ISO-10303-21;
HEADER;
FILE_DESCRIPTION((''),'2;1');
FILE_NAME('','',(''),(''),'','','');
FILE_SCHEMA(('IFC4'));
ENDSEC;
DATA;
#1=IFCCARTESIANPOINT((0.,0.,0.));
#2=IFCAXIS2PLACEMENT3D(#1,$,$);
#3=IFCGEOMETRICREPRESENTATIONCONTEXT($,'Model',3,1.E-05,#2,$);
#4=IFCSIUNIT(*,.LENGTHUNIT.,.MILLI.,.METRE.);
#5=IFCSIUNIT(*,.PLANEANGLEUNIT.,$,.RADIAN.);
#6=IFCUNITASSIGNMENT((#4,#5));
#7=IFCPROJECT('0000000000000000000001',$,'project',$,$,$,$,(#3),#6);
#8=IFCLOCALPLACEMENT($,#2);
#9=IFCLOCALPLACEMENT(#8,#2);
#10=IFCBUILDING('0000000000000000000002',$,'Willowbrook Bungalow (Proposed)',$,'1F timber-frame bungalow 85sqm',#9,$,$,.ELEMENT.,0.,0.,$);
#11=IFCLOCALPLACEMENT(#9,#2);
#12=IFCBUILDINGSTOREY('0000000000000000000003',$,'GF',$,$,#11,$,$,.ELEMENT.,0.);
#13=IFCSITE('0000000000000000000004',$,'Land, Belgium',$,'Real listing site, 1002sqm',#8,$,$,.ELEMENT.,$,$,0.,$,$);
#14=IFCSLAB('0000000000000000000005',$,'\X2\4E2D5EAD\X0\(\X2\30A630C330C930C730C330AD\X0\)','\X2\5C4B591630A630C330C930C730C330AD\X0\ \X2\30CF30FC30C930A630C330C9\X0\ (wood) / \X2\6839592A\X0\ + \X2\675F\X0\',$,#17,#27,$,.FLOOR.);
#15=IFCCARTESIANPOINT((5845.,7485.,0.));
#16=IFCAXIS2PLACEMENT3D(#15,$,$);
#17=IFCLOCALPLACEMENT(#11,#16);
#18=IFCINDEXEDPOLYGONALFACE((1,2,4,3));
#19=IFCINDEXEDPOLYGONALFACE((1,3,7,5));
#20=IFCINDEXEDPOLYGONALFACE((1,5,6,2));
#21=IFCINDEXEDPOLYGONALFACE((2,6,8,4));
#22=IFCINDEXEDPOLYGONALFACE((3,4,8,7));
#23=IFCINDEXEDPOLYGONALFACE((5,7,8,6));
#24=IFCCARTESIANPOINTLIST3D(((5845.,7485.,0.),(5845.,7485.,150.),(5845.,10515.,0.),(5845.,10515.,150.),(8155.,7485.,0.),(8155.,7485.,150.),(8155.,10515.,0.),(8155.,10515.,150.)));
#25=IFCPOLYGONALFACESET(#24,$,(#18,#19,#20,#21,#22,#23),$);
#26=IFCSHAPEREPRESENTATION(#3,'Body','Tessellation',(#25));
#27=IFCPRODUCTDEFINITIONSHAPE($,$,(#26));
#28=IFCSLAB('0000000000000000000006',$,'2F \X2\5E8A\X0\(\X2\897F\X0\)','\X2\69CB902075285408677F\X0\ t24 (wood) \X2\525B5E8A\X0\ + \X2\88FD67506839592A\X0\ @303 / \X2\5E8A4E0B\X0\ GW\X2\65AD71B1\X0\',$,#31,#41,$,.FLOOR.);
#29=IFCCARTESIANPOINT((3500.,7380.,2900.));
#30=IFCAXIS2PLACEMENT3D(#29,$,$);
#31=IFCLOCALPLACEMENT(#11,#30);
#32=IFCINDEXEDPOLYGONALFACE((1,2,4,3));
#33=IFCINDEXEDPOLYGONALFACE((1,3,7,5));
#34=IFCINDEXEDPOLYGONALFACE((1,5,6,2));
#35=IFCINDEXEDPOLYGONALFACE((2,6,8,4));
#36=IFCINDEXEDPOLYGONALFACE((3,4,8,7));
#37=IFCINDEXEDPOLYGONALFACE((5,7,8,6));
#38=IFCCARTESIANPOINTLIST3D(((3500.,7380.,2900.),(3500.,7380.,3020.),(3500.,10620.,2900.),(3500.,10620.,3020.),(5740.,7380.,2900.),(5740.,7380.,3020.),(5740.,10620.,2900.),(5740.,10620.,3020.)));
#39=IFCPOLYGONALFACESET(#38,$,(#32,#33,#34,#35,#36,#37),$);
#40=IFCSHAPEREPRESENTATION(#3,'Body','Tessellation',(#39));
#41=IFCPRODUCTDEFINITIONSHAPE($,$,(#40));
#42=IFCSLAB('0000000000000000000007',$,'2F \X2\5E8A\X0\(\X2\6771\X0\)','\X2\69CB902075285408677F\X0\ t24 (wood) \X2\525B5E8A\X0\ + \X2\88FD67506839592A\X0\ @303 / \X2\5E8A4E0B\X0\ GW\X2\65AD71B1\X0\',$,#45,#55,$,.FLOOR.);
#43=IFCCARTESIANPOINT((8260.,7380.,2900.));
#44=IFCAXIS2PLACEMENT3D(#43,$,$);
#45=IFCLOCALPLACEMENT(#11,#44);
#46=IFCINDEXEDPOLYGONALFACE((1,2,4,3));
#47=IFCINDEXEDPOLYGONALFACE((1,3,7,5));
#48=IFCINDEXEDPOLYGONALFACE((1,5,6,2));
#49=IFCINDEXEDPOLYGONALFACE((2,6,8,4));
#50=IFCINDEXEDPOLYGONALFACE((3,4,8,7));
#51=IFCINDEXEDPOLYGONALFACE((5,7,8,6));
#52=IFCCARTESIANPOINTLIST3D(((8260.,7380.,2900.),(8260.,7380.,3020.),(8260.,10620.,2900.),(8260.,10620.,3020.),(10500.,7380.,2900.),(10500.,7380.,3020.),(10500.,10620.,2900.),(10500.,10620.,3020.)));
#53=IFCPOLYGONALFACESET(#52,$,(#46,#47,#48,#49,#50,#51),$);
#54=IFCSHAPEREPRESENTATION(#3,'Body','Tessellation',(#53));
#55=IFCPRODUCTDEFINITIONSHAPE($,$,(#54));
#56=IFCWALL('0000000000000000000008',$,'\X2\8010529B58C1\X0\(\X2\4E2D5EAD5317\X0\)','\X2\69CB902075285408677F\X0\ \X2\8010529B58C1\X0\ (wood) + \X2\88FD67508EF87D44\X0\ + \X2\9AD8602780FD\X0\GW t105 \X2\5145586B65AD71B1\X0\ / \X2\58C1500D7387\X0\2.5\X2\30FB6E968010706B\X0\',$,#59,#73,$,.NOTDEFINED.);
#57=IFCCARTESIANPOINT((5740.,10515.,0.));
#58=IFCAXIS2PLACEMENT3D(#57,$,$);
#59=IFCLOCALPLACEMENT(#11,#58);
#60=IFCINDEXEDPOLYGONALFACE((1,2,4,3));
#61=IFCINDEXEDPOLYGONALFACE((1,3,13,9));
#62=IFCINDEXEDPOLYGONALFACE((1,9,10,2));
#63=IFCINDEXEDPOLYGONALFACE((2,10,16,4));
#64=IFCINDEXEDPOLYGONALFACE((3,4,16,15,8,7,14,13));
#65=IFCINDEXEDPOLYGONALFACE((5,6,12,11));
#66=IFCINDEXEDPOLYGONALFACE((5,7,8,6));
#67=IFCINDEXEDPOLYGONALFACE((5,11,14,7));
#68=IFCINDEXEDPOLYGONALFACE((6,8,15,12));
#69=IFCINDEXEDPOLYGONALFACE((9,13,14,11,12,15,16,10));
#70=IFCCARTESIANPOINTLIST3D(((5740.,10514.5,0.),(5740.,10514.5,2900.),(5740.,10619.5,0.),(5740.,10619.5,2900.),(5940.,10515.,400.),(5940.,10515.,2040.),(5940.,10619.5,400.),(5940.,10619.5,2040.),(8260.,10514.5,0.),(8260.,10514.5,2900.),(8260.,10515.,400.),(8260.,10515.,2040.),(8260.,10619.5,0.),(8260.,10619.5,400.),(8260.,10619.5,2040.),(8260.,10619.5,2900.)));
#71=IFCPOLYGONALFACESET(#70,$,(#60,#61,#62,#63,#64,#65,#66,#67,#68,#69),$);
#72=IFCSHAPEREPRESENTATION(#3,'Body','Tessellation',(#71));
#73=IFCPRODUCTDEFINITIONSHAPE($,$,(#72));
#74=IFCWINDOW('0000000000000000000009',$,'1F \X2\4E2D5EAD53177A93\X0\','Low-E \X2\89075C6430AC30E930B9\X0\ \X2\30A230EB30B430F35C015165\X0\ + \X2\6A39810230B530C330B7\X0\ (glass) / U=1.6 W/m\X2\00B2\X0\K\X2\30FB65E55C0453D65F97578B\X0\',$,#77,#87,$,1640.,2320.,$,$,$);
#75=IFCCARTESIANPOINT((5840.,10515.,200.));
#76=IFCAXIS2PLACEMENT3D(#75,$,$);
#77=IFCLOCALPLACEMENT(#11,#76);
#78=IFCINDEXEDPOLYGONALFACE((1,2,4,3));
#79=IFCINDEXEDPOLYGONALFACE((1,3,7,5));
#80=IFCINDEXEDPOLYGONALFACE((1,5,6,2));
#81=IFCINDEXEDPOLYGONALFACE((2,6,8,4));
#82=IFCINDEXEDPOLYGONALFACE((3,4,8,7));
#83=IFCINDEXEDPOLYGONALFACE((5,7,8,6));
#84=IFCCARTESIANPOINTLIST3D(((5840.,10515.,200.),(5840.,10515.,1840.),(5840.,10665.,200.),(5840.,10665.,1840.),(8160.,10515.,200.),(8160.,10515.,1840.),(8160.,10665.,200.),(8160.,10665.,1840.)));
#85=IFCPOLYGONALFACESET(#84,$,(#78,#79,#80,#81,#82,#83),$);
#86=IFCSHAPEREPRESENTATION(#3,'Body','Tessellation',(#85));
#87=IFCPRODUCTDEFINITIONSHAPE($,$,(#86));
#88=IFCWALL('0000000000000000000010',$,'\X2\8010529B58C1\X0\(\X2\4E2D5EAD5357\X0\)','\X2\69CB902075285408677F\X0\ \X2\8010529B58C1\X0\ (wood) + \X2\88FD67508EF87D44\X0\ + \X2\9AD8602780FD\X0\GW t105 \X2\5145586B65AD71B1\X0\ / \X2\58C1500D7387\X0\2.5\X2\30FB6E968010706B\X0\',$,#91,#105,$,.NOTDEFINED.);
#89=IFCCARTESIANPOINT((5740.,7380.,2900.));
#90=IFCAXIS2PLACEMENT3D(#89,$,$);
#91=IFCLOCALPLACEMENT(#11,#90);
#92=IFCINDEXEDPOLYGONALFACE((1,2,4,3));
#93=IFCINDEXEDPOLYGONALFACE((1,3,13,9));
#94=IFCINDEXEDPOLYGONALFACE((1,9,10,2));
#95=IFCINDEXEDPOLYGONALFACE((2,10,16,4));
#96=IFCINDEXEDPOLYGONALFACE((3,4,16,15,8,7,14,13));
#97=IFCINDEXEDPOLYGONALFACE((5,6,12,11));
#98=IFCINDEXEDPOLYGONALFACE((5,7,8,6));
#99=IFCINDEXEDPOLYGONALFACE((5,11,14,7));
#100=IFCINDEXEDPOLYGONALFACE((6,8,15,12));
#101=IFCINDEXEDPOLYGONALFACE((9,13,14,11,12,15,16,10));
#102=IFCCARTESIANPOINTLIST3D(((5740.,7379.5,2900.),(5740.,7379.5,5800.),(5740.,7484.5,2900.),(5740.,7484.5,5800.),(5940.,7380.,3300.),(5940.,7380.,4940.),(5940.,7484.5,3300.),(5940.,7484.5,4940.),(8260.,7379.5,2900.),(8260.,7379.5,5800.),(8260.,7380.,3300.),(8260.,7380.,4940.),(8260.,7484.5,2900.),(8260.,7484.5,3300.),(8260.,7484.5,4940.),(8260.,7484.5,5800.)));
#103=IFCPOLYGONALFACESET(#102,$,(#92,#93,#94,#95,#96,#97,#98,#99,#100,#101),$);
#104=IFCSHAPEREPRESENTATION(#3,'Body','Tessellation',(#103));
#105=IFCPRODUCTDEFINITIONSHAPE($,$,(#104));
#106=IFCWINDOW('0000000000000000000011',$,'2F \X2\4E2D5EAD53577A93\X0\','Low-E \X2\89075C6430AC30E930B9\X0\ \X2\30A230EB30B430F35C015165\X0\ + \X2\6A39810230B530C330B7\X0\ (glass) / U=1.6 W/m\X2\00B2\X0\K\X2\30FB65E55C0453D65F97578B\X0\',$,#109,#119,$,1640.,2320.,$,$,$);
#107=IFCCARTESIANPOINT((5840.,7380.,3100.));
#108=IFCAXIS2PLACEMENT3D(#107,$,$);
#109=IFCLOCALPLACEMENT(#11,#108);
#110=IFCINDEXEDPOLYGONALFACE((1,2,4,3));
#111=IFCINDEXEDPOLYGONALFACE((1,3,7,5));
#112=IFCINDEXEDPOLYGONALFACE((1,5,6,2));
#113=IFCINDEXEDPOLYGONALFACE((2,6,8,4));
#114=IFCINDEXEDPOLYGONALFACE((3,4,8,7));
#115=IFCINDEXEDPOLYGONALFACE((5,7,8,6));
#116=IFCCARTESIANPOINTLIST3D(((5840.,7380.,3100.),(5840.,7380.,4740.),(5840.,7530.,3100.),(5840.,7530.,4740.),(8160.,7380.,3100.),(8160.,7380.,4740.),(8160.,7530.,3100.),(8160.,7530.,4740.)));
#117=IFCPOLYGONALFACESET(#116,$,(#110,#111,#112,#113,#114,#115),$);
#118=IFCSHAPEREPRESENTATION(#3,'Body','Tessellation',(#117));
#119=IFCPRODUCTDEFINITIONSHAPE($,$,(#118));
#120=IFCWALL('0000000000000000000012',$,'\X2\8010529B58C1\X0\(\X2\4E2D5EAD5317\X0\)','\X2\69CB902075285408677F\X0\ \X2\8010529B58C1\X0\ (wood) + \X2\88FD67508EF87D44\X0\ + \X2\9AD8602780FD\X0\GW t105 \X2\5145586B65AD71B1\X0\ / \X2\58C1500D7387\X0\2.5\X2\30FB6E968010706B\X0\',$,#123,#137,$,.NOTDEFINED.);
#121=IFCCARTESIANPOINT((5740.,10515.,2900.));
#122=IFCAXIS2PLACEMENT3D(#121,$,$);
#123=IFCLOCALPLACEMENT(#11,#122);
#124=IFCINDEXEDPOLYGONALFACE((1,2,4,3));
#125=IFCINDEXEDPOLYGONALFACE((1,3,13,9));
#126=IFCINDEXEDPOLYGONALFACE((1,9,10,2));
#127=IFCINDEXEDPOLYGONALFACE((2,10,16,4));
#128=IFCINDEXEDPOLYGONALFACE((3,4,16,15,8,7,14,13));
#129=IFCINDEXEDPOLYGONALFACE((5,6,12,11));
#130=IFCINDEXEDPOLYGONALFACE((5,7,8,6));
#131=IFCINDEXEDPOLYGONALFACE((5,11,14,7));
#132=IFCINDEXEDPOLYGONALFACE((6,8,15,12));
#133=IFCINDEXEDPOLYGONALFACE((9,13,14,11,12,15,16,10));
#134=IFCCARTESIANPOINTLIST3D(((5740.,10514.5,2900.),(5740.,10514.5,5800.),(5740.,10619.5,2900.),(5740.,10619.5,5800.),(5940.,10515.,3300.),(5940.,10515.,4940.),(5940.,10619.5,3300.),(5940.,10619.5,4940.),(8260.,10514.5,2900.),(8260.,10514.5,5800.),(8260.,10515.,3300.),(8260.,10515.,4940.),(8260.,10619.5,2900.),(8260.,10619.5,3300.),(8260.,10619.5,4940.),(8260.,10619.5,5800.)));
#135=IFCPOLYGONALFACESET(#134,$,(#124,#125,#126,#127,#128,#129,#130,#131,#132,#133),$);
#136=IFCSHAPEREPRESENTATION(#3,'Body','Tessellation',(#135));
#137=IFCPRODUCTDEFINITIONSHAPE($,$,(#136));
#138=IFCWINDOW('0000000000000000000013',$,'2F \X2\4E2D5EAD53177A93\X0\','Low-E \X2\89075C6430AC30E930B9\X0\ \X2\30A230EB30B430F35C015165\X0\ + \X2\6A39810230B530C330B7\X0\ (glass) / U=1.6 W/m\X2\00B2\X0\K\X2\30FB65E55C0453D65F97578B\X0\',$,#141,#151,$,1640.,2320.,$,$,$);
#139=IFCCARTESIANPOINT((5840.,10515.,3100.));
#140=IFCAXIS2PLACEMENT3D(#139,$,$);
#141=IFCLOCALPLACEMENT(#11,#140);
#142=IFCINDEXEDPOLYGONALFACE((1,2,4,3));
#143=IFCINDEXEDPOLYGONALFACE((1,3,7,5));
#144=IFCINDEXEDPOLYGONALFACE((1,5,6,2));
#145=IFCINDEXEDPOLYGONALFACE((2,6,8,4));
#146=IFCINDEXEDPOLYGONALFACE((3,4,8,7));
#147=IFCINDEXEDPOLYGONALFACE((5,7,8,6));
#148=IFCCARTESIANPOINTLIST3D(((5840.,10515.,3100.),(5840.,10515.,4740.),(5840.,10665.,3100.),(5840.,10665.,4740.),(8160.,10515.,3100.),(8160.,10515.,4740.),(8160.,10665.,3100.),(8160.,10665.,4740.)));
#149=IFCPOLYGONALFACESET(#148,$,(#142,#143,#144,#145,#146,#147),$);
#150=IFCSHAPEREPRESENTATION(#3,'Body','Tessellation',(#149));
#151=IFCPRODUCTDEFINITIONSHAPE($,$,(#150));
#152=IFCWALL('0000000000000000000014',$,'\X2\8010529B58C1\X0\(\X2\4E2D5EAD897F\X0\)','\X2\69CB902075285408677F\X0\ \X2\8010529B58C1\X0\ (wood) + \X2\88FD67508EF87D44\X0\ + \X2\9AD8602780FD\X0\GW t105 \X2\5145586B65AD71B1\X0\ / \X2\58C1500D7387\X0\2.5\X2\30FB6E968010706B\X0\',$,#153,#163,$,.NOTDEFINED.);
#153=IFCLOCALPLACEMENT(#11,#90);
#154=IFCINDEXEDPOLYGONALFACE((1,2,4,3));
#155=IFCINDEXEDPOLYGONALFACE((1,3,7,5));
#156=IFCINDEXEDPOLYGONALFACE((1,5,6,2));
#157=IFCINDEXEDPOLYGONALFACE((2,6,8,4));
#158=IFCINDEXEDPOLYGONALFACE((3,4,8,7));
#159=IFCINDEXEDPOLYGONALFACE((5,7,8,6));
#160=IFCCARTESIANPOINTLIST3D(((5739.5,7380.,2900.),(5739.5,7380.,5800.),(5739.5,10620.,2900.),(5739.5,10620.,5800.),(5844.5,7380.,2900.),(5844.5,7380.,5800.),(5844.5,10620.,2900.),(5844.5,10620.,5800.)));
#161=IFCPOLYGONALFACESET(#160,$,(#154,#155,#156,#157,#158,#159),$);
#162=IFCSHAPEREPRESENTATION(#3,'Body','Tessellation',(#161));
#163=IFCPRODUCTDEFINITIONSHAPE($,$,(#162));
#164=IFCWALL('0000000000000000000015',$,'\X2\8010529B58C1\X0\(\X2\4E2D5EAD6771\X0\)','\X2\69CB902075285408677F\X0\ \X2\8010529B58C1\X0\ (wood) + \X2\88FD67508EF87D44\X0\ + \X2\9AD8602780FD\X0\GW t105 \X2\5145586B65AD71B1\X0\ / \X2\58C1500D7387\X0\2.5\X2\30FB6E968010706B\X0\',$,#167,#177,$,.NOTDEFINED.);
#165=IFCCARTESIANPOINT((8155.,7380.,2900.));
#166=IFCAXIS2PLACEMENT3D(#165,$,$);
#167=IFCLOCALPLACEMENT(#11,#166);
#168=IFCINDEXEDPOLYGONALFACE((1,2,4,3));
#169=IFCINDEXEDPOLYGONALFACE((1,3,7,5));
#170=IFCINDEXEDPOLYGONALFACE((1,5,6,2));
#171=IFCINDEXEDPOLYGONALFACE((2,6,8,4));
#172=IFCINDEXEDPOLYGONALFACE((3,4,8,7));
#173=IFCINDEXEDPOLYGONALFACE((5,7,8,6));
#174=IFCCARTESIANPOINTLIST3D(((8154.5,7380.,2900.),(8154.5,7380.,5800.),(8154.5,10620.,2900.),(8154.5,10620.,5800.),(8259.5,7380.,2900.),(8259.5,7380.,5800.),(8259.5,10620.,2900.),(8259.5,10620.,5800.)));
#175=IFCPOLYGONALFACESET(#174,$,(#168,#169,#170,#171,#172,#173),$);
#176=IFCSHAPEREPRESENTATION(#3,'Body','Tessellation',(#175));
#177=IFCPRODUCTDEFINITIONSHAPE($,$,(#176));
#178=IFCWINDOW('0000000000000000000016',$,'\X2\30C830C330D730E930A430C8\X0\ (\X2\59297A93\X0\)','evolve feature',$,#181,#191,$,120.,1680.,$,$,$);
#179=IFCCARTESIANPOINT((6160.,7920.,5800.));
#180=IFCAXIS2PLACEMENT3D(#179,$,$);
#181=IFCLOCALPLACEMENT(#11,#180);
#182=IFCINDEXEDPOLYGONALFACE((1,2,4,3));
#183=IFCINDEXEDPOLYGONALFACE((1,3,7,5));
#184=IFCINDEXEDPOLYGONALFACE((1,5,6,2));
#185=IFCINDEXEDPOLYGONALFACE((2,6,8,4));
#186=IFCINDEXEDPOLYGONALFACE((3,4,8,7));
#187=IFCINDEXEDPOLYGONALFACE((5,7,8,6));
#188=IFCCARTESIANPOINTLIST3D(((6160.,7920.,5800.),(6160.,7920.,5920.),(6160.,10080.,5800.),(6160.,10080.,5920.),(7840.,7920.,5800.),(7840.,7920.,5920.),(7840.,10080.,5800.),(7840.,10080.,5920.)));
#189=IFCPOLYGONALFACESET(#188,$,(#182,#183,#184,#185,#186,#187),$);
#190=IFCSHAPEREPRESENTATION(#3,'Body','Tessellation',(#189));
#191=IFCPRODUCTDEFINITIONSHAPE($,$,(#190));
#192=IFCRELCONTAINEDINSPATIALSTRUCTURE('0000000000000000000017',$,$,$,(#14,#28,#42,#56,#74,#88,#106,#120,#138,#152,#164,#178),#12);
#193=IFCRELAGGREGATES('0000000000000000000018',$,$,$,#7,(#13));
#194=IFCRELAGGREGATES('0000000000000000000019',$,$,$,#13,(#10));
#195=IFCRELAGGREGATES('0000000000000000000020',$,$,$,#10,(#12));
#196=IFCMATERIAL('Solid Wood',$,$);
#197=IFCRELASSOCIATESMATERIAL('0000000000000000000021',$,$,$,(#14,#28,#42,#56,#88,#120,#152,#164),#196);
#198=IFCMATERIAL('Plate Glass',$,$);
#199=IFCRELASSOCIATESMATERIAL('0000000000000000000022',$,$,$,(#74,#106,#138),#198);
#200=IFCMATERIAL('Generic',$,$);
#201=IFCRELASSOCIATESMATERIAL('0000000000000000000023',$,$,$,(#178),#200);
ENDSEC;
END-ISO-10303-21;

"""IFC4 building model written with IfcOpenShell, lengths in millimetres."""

from ifc_helpers import new_model, si_unit, frame, frame_2d, origin, place, context, project, spatial, rectangle, extrude, material, element, fill, save


model = new_model("IFC4")

# Units and contexts
model_context = context("Model", 3, precision=1e-05, world=origin())
ifc_project = project(units=[si_unit("LENGTHUNIT", "METRE", prefix="MILLI"), si_unit("PLANEANGLEUNIT", "RADIAN")], contexts=[model_context])

# Site, building, storey
site_placement = place(None, origin())
site = spatial("IfcSite", under=ifc_project, at=site_placement, Name="Land, Belgium", ObjectType="Real listing site, 1002sqm", CompositionType="ELEMENT", RefElevation=0.0)
building_placement = place(site_placement, origin())
building = spatial("IfcBuilding", under=site, at=building_placement, Name="Willowbrook Bungalow (Proposed)", ObjectType="1F timber-frame bungalow 85sqm", CompositionType="ELEMENT", ElevationOfRefHeight=0.0, ElevationOfTerrain=0.0)
storey_placement = place(building_placement, origin())
storey = spatial("IfcBuildingStorey", under=building, at=storey_placement, Name="GF", CompositionType="ELEMENT", Elevation=0.0)

# Slabs
ifc_material_1 = material(Name="Solid Wood")
slab_1_placement = place(storey_placement, frame((5845.0, 7485.0, 0.0)))
element("IfcSlab", 1, at=slab_1_placement, inside=storey, material=ifc_material_1, Name="中庭(ウッドデッキ)", Description="屋外ウッドデッキ ハードウッド (wood) / 根太 + 束", PredefinedType="FLOOR", context=model_context, shape_type="SweptSolid", body=[
    extrude(rectangle(XDim=2310.0, YDim=3030.0, at=frame_2d((1155.0, 1515.0))), frame((5845.0, 7485.0, 0.0)), (0.0, 0.0, 1.0), 150.0),
])
slab_2_placement = place(storey_placement, frame((3500.0, 7380.0, 2900.0)))
element("IfcSlab", 2, at=slab_2_placement, inside=storey, material=ifc_material_1, Name="2F 床(西)", Description="構造用合板 t24 (wood) 剛床 + 製材根太 @303 / 床下 GW断熱", PredefinedType="FLOOR", context=model_context, shape_type="SweptSolid", body=[
    extrude(rectangle(XDim=2240.0, YDim=3240.0, at=frame_2d((1120.0, 1620.0))), frame((3500.0, 7380.0, 2900.0)), (0.0, 0.0, 1.0), 120.0),
])
slab_3_placement = place(storey_placement, frame((8260.0, 7380.0, 2900.0)))
element("IfcSlab", 3, at=slab_3_placement, inside=storey, material=ifc_material_1, Name="2F 床(東)", Description="構造用合板 t24 (wood) 剛床 + 製材根太 @303 / 床下 GW断熱", PredefinedType="FLOOR", context=model_context, shape_type="SweptSolid", body=[
    extrude(rectangle(XDim=2240.0, YDim=3240.0, at=frame_2d((1120.0, 1620.0))), frame((8260.0, 7380.0, 2900.0)), (0.0, 0.0, 1.0), 120.0),
])

# Walls, openings, windows
wall_1_placement = place(storey_placement, frame((5740.0, 10515.0, 0.0)))
wall_1 = element("IfcWall", 4, at=wall_1_placement, inside=storey, material=ifc_material_1, Name="耐力壁(中庭北)", Description="構造用合板 耐力壁 (wood) + 製材軸組 + 高性能GW t105 充填断熱 / 壁倍率2.5・準耐火", PredefinedType="NOTDEFINED", context=model_context, shape_type="SweptSolid", body=[
    extrude(rectangle(XDim=2520.0, YDim=105.0, at=frame_2d((1260.0, 52.0))), frame((5740.0, 10515.0, 0.0)), (0.0, 0.0, 1.0), 2900.0),
])
opening_1_placement = place(storey_placement, frame((5840.0, 10515.0, 200.0)))
opening_1 = element("IfcOpeningElement", 5, at=opening_1_placement, cuts=wall_1, PredefinedType="NOTDEFINED", context=model_context, shape_type="SweptSolid", body=[
    extrude(rectangle(XDim=2320.0, YDim=150.0, at=frame_2d((1160.0, 75.0))), frame((5840.0, 10515.0, 200.0)), (0.0, 0.0, 1.0), 1640.0),
])
ifc_material_2 = material(Name="Plate Glass")
window_1_placement = place(storey_placement, frame((5840.0, 10515.0, 200.0)))
window_1 = element("IfcWindow", 6, at=window_1_placement, inside=storey, material=ifc_material_2, Name="1F 中庭北窓", Description="Low-E 複層ガラス アルゴン封入 + 樹脂サッシ (glass) / U=1.6 W/m²K・日射取得型", OverallHeight=1640.0, OverallWidth=2320.0, context=model_context, shape_type="SweptSolid", body=[
    extrude(rectangle(XDim=2320.0, YDim=150.0, at=frame_2d((1160.0, 75.0))), frame((5840.0, 10515.0, 200.0)), (0.0, 0.0, 1.0), 1640.0),
])
fill(opening_1, window_1)
wall_2_placement = place(storey_placement, frame((5740.0, 7380.0, 2900.0)))
wall_2 = element("IfcWall", 7, at=wall_2_placement, inside=storey, material=ifc_material_1, Name="耐力壁(中庭南)", Description="構造用合板 耐力壁 (wood) + 製材軸組 + 高性能GW t105 充填断熱 / 壁倍率2.5・準耐火", PredefinedType="NOTDEFINED", context=model_context, shape_type="SweptSolid", body=[
    extrude(rectangle(XDim=2520.0, YDim=105.0, at=frame_2d((1260.0, 52.0))), frame((5740.0, 7380.0, 2900.0)), (0.0, 0.0, 1.0), 2900.0),
])
opening_2_placement = place(storey_placement, frame((5840.0, 7380.0, 3100.0)))
opening_2 = element("IfcOpeningElement", 8, at=opening_2_placement, cuts=wall_2, PredefinedType="NOTDEFINED", context=model_context, shape_type="SweptSolid", body=[
    extrude(rectangle(XDim=2320.0, YDim=150.0, at=frame_2d((1160.0, 75.0))), frame((5840.0, 7380.0, 3100.0)), (0.0, 0.0, 1.0), 1640.0),
])
window_2_placement = place(storey_placement, frame((5840.0, 7380.0, 3100.0)))
window_2 = element("IfcWindow", 9, at=window_2_placement, inside=storey, material=ifc_material_2, Name="2F 中庭南窓", Description="Low-E 複層ガラス アルゴン封入 + 樹脂サッシ (glass) / U=1.6 W/m²K・日射取得型", OverallHeight=1640.0, OverallWidth=2320.0, context=model_context, shape_type="SweptSolid", body=[
    extrude(rectangle(XDim=2320.0, YDim=150.0, at=frame_2d((1160.0, 75.0))), frame((5840.0, 7380.0, 3100.0)), (0.0, 0.0, 1.0), 1640.0),
])
fill(opening_2, window_2)
wall_3_placement = place(storey_placement, frame((5740.0, 10515.0, 2900.0)))
wall_3 = element("IfcWall", 10, at=wall_3_placement, inside=storey, material=ifc_material_1, Name="耐力壁(中庭北)", Description="構造用合板 耐力壁 (wood) + 製材軸組 + 高性能GW t105 充填断熱 / 壁倍率2.5・準耐火", PredefinedType="NOTDEFINED", context=model_context, shape_type="SweptSolid", body=[
    extrude(rectangle(XDim=2520.0, YDim=105.0, at=frame_2d((1260.0, 52.0))), frame((5740.0, 10515.0, 2900.0)), (0.0, 0.0, 1.0), 2900.0),
])
opening_3_placement = place(storey_placement, frame((5840.0, 10515.0, 3100.0)))
opening_3 = element("IfcOpeningElement", 11, at=opening_3_placement, cuts=wall_3, PredefinedType="NOTDEFINED", context=model_context, shape_type="SweptSolid", body=[
    extrude(rectangle(XDim=2320.0, YDim=150.0, at=frame_2d((1160.0, 75.0))), frame((5840.0, 10515.0, 3100.0)), (0.0, 0.0, 1.0), 1640.0),
])
window_3_placement = place(storey_placement, frame((5840.0, 10515.0, 3100.0)))
window_3 = element("IfcWindow", 12, at=window_3_placement, inside=storey, material=ifc_material_2, Name="2F 中庭北窓", Description="Low-E 複層ガラス アルゴン封入 + 樹脂サッシ (glass) / U=1.6 W/m²K・日射取得型", OverallHeight=1640.0, OverallWidth=2320.0, context=model_context, shape_type="SweptSolid", body=[
    extrude(rectangle(XDim=2320.0, YDim=150.0, at=frame_2d((1160.0, 75.0))), frame((5840.0, 10515.0, 3100.0)), (0.0, 0.0, 1.0), 1640.0),
])
fill(opening_3, window_3)

# Walls
wall_4_placement = place(storey_placement, frame((5740.0, 7380.0, 2900.0)))
element("IfcWall", 13, at=wall_4_placement, inside=storey, material=ifc_material_1, Name="耐力壁(中庭西)", Description="構造用合板 耐力壁 (wood) + 製材軸組 + 高性能GW t105 充填断熱 / 壁倍率2.5・準耐火", PredefinedType="NOTDEFINED", context=model_context, shape_type="SweptSolid", body=[
    extrude(rectangle(XDim=105.0, YDim=3240.0, at=frame_2d((52.0, 1620.0))), frame((5740.0, 7380.0, 2900.0)), (0.0, 0.0, 1.0), 2900.0),
])
wall_5_placement = place(storey_placement, frame((8155.0, 7380.0, 2900.0)))
element("IfcWall", 14, at=wall_5_placement, inside=storey, material=ifc_material_1, Name="耐力壁(中庭東)", Description="構造用合板 耐力壁 (wood) + 製材軸組 + 高性能GW t105 充填断熱 / 壁倍率2.5・準耐火", PredefinedType="NOTDEFINED", context=model_context, shape_type="SweptSolid", body=[
    extrude(rectangle(XDim=105.0, YDim=3240.0, at=frame_2d((52.0, 1620.0))), frame((8155.0, 7380.0, 2900.0)), (0.0, 0.0, 1.0), 2900.0),
])

# Window
ifc_material_3 = material(Name="Generic")
window_4_placement = place(storey_placement, frame((6160.0, 7920.0, 5800.0)))
element("IfcWindow", 15, at=window_4_placement, inside=storey, material=ifc_material_3, Name="トップライト (天窓)", Description="evolve feature", OverallHeight=120.0, OverallWidth=1680.0, context=model_context, shape_type="SweptSolid", body=[
    extrude(rectangle(XDim=1680.0, YDim=2160.0, at=frame_2d((840.0, 1080.0))), frame((6160.0, 7920.0, 5800.0)), (0.0, 0.0, 1.0), 120.0),
])

save(model, "model.ifc")
